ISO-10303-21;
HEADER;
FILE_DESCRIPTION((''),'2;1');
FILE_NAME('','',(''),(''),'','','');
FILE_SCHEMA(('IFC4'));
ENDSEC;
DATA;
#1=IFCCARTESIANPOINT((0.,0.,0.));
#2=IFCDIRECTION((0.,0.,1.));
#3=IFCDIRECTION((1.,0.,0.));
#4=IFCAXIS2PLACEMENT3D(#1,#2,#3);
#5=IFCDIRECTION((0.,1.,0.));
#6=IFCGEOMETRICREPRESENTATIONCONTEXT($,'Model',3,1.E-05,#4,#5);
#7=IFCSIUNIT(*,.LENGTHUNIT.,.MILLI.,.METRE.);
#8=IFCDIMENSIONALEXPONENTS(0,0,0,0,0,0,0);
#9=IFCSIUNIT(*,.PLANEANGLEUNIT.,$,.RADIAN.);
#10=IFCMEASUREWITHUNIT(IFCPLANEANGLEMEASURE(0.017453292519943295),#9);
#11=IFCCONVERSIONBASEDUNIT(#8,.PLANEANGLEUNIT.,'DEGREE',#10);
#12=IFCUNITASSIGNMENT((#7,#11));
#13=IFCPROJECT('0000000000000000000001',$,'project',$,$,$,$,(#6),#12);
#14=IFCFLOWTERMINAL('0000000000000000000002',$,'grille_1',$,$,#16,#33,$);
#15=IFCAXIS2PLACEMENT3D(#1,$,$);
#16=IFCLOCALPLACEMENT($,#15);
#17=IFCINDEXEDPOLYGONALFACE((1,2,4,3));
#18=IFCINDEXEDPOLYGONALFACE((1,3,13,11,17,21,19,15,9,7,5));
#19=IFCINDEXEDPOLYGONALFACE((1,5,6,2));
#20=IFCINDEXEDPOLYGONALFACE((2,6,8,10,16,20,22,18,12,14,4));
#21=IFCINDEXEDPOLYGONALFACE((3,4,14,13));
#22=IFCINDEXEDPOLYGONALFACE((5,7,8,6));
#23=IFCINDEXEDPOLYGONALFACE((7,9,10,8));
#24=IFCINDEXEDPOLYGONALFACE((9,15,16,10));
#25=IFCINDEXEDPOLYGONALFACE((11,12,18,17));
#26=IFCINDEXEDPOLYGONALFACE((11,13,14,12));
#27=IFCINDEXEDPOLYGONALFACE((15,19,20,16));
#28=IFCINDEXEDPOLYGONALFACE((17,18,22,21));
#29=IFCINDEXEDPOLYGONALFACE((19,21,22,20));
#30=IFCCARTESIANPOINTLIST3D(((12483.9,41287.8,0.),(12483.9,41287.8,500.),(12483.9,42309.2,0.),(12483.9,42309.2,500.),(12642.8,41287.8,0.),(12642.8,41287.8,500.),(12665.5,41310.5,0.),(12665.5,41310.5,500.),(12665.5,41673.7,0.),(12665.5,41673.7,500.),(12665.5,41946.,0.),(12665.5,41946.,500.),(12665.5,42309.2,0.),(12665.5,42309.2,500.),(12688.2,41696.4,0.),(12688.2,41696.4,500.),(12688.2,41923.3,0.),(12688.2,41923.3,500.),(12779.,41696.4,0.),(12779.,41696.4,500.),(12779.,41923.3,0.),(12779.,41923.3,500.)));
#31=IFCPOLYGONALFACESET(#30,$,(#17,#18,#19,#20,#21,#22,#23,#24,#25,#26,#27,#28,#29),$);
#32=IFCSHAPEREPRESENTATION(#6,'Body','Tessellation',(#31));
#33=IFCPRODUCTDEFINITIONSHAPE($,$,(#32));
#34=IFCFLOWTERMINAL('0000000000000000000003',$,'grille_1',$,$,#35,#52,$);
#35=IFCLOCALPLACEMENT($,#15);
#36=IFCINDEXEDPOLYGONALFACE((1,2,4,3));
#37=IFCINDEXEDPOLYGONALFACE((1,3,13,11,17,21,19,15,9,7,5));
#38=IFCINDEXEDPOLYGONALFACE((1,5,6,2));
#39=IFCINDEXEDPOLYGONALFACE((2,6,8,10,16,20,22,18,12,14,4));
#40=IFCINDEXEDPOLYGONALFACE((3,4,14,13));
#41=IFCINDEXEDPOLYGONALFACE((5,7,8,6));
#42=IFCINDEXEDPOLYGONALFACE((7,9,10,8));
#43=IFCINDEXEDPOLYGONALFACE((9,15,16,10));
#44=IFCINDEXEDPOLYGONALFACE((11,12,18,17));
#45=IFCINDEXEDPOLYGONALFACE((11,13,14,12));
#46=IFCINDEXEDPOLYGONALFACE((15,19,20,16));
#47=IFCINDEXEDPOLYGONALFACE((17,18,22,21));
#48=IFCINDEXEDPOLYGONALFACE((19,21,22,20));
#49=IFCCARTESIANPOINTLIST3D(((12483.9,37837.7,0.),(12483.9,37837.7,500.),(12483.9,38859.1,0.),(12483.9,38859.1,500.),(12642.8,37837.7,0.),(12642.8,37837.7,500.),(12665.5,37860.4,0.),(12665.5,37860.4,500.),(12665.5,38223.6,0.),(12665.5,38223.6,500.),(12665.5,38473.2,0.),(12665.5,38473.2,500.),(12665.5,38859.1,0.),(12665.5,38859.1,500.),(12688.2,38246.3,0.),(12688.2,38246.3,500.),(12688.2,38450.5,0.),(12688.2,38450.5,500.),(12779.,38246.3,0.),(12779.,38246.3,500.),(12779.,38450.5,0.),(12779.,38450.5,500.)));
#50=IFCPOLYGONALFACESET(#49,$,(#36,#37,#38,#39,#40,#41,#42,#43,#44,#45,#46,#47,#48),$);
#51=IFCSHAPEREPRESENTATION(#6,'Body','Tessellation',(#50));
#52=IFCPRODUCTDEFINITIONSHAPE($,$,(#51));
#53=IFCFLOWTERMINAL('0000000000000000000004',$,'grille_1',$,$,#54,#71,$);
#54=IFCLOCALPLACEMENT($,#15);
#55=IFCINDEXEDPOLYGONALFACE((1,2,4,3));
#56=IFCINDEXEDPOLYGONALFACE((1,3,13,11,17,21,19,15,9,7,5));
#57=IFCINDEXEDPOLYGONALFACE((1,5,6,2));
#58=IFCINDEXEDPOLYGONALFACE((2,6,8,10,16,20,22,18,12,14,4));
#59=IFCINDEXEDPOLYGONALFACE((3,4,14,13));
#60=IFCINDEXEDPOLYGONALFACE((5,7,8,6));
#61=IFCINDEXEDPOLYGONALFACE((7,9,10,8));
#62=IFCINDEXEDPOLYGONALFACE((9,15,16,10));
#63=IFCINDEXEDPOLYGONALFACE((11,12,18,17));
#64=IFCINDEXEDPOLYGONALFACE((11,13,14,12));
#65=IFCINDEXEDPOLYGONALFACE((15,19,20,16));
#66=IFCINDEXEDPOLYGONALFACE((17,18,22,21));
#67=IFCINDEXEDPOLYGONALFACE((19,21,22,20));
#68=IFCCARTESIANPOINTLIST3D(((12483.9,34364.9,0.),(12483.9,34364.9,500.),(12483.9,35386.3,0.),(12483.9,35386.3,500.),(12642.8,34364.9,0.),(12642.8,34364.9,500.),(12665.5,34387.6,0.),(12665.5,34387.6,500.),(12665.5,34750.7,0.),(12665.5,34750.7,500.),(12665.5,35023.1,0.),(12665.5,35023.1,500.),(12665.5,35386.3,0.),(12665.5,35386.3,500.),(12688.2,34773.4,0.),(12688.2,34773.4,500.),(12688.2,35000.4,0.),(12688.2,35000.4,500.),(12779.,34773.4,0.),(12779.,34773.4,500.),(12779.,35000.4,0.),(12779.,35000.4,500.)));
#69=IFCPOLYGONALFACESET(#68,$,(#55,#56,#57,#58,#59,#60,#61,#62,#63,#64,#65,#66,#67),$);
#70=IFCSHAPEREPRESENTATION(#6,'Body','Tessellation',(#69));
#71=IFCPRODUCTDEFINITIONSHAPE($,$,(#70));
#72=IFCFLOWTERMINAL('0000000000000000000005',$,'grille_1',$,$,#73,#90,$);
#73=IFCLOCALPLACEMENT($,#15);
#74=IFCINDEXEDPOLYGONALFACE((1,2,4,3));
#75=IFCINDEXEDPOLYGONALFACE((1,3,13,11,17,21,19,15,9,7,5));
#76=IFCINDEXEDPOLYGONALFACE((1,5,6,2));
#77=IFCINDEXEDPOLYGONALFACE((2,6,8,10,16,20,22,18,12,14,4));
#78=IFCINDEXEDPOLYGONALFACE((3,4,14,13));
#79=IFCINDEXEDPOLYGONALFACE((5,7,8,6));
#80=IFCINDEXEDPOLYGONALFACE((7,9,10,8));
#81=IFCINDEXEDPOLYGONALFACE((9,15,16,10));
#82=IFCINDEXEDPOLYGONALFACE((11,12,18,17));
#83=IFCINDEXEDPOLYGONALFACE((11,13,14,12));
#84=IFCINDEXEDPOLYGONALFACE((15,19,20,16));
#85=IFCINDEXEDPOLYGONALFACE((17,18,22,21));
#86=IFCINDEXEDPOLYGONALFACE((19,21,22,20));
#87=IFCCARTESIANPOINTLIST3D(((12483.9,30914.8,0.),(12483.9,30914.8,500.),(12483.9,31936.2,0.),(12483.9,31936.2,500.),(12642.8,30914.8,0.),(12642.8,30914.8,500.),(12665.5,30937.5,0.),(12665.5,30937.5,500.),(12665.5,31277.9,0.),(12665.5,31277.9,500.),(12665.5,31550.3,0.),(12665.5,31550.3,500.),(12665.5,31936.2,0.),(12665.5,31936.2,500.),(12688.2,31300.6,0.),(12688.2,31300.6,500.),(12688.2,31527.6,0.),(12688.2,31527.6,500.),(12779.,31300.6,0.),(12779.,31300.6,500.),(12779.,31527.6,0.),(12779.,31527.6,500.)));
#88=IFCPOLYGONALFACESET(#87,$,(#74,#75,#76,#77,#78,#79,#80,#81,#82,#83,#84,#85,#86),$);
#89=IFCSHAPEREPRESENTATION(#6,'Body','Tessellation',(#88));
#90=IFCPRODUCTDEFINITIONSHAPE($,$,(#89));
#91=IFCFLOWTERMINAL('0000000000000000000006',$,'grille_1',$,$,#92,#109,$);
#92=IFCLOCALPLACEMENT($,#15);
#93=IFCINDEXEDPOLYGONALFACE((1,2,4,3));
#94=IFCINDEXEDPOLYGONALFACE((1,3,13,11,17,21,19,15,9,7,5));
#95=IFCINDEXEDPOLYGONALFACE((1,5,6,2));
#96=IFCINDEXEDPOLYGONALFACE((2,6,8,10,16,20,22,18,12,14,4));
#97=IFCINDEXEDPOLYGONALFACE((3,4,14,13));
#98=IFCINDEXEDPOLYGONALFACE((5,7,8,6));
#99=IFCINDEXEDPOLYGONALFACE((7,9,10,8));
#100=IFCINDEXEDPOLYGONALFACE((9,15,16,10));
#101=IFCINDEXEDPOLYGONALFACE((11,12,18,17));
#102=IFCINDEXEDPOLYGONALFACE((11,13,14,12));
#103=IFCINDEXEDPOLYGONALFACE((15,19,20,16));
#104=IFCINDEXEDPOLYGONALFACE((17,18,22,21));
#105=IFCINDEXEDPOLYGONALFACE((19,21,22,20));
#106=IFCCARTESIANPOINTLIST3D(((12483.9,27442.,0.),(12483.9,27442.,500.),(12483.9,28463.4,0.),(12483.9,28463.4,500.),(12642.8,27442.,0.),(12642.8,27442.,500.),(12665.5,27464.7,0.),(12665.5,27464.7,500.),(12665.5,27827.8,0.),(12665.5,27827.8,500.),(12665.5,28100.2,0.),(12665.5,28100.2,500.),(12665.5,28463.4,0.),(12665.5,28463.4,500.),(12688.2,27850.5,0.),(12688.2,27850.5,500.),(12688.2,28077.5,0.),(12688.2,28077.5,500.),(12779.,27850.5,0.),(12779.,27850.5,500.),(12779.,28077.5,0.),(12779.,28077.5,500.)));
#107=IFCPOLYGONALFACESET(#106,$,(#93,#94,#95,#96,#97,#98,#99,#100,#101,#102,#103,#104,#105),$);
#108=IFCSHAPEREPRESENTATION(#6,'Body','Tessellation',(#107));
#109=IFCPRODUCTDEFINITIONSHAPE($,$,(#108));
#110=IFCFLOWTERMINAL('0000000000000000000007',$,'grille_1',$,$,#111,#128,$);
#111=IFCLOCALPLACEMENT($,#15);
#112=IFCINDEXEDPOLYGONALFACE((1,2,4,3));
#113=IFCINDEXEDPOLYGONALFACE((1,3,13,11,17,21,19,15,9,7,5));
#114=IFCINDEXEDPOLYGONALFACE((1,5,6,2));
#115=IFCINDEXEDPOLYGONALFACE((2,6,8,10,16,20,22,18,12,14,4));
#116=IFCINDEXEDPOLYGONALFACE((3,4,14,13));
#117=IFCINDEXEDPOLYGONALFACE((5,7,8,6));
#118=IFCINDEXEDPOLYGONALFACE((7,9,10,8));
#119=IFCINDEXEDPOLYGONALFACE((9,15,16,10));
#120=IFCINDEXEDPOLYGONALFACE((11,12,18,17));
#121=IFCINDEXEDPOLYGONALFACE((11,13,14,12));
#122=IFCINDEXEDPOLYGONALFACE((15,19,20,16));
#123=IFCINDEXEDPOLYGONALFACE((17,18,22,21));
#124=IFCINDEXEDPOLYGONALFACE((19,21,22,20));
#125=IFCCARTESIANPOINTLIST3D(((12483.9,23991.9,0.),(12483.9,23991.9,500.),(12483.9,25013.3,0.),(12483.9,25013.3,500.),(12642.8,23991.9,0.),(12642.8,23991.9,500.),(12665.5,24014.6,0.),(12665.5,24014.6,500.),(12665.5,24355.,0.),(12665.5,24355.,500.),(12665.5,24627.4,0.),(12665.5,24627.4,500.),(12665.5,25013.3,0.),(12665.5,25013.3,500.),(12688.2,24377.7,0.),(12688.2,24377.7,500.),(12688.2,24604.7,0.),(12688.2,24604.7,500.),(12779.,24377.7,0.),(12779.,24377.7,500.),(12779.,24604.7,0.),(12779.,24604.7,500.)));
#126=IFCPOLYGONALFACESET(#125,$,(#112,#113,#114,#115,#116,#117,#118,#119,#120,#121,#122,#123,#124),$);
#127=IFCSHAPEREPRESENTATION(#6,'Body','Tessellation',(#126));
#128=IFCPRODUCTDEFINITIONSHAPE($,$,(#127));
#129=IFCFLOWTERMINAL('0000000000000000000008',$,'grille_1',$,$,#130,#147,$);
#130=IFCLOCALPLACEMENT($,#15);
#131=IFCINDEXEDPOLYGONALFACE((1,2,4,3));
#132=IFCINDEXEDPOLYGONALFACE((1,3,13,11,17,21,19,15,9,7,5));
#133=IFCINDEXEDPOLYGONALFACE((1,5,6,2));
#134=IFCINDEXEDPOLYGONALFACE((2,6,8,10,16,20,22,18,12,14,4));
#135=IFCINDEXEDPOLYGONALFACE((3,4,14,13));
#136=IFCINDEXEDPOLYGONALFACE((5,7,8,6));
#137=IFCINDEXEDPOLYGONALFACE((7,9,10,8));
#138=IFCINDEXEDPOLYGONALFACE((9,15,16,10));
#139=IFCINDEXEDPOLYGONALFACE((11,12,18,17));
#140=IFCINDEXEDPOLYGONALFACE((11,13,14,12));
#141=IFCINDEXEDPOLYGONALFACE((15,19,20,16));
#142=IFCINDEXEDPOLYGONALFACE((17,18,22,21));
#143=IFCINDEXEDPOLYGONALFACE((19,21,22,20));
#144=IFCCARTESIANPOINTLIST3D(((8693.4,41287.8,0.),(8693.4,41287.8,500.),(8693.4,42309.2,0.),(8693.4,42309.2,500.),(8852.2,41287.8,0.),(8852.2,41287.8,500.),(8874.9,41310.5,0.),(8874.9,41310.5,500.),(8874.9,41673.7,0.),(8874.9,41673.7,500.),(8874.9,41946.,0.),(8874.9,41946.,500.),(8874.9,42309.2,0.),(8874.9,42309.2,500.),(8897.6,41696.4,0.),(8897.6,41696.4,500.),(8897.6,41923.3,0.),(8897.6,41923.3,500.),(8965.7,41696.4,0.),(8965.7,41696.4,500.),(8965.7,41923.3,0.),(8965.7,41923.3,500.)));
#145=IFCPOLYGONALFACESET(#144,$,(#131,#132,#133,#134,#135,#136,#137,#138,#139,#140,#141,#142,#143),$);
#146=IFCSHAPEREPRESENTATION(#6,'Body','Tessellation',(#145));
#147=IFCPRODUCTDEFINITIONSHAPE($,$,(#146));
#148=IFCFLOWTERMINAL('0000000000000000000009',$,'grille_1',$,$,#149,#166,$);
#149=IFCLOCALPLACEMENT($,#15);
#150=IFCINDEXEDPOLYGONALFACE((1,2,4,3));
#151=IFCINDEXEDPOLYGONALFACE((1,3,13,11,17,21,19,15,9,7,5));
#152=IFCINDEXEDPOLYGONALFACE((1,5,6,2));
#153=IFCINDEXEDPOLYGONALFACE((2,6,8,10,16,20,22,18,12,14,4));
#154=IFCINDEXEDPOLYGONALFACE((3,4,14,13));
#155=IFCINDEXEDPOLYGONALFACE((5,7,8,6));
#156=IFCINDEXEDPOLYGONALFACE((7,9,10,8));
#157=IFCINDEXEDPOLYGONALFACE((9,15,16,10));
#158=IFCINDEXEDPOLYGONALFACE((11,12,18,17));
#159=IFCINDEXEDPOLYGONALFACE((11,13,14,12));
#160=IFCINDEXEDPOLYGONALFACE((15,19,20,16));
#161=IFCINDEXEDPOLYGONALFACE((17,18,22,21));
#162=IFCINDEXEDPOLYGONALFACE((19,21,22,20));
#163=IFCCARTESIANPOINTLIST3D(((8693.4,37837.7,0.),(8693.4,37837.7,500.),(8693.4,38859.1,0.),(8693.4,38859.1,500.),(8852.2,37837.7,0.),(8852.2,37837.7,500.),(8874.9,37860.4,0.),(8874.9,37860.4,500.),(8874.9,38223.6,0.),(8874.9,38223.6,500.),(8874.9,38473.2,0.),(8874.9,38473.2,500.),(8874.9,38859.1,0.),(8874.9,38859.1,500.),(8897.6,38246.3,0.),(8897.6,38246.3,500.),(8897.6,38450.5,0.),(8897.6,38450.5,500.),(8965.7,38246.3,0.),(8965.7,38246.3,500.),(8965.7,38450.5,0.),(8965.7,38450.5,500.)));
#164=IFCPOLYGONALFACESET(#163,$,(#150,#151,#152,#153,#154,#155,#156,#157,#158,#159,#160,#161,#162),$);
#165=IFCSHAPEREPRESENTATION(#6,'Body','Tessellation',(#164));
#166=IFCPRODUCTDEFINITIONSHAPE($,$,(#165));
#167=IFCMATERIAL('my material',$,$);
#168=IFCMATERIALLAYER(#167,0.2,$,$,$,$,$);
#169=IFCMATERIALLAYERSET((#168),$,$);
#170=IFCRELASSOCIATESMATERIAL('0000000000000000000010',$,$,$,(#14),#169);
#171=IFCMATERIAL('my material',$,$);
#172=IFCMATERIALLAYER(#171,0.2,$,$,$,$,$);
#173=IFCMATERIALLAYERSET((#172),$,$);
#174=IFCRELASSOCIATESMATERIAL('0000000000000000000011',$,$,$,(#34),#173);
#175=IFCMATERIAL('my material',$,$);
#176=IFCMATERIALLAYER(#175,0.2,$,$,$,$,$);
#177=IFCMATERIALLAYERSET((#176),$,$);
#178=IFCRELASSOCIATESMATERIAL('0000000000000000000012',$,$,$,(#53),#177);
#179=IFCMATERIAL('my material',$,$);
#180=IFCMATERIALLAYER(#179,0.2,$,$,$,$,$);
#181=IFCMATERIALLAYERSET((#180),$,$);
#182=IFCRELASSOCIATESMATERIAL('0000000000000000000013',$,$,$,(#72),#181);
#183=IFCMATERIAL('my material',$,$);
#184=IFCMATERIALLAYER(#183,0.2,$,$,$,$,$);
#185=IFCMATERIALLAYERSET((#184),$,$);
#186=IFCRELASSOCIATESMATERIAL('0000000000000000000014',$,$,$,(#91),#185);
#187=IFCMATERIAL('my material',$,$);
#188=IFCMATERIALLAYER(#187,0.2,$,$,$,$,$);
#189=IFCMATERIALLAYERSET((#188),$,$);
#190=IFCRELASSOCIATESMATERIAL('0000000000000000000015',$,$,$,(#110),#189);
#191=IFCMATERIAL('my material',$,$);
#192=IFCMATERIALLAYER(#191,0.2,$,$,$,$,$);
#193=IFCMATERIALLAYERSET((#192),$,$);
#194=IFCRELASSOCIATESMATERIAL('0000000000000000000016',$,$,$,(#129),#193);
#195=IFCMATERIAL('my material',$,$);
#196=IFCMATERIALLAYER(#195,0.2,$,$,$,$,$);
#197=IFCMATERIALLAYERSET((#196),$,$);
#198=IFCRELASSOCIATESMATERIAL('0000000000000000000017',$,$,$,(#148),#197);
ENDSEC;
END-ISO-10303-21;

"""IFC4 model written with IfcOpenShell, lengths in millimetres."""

from ifc_helpers import new_model, entity, si_unit, converted_unit, direction, origin_with_axes, place, context, project, polyline, outline, extrude, material, layer, layer_set, layer_usage, element, save


model = new_model("IFC4")

# Units and contexts
model_context = context("Model", 3, precision=1e-05, world=origin_with_axes(), true_north=direction((0.0, 1.0, 0.0)))
ifc_project = project(units=[si_unit("LENGTHUNIT", "METRE", prefix="MILLI"), converted_unit("PLANEANGLEUNIT", "DEGREE", entity("IfcPlaneAngleMeasure", 0.017453292519943295), si_unit("PLANEANGLEUNIT", "RADIAN"), dimensions=[0, 0, 0, 0, 0, 0, 0])], contexts=[model_context])

# Flow terminals
ifc_material_1 = material(Name="my material")
ifc_layer_1 = layer(ifc_material_1, 0.2)
ifc_layer_set_1 = layer_set([ifc_layer_1])
ifc_layer_usage_1 = layer_usage(ifc_layer_set_1, "AXIS2", "POSITIVE", -0.1)
flow_terminal_1_placement = place(None, origin_with_axes())
element("IfcFlowTerminal", 1, at=flow_terminal_1_placement, material=ifc_layer_usage_1, Name="grille_1", context=model_context, shape_type="SweptSolid", body=[
    extrude(outline(polyline([(12483.9, 41287.8), (12642.8, 41287.8), (12665.5, 41310.5), (12665.5, 41673.7), (12688.2, 41696.4), (12779.0, 41696.4), (12779.0, 41923.3), (12688.2, 41923.3), (12665.5, 41946.0), (12665.5, 42309.2), (12483.9, 42309.2), (12483.9, 41287.8)])), origin_with_axes(), (0.0, 0.0, 1.0), 500.0),
])
ifc_material_2 = material(Name="my material")
ifc_layer_2 = layer(ifc_material_2, 0.2)
ifc_layer_set_2 = layer_set([ifc_layer_2])
ifc_layer_usage_2 = layer_usage(ifc_layer_set_2, "AXIS2", "POSITIVE", -0.1)
flow_terminal_2_placement = place(None, origin_with_axes())
element("IfcFlowTerminal", 2, at=flow_terminal_2_placement, material=ifc_layer_usage_2, Name="grille_1", context=model_context, shape_type="SweptSolid", body=[
    extrude(outline(polyline([(12483.9, 37837.7), (12642.8, 37837.7), (12665.5, 37860.4), (12665.5, 38223.6), (12688.2, 38246.3), (12779.0, 38246.3), (12779.0, 38450.5), (12688.2, 38450.5), (12665.5, 38473.2), (12665.5, 38859.1), (12483.9, 38859.1), (12483.9, 37837.7)])), origin_with_axes(), (0.0, 0.0, 1.0), 500.0),
])
ifc_material_3 = material(Name="my material")
ifc_layer_3 = layer(ifc_material_3, 0.2)
ifc_layer_set_3 = layer_set([ifc_layer_3])
ifc_layer_usage_3 = layer_usage(ifc_layer_set_3, "AXIS2", "POSITIVE", -0.1)
flow_terminal_3_placement = place(None, origin_with_axes())
element("IfcFlowTerminal", 3, at=flow_terminal_3_placement, material=ifc_layer_usage_3, Name="grille_1", context=model_context, shape_type="SweptSolid", body=[
    extrude(outline(polyline([(12483.9, 34364.9), (12642.8, 34364.9), (12665.5, 34387.6), (12665.5, 34750.7), (12688.2, 34773.4), (12779.0, 34773.4), (12779.0, 35000.4), (12688.2, 35000.4), (12665.5, 35023.1), (12665.5, 35386.3), (12483.9, 35386.3), (12483.9, 34364.9)])), origin_with_axes(), (0.0, 0.0, 1.0), 500.0),
])
ifc_material_4 = material(Name="my material")
ifc_layer_4 = layer(ifc_material_4, 0.2)
ifc_layer_set_4 = layer_set([ifc_layer_4])
ifc_layer_usage_4 = layer_usage(ifc_layer_set_4, "AXIS2", "POSITIVE", -0.1)
flow_terminal_4_placement = place(None, origin_with_axes())
element("IfcFlowTerminal", 4, at=flow_terminal_4_placement, material=ifc_layer_usage_4, Name="grille_1", context=model_context, shape_type="SweptSolid", body=[
    extrude(outline(polyline([(12483.9, 30914.8), (12642.8, 30914.8), (12665.5, 30937.5), (12665.5, 31277.9), (12688.2, 31300.6), (12779.0, 31300.6), (12779.0, 31527.6), (12688.2, 31527.6), (12665.5, 31550.3), (12665.5, 31936.2), (12483.9, 31936.2), (12483.9, 30914.8)])), origin_with_axes(), (0.0, 0.0, 1.0), 500.0),
])
ifc_material_5 = material(Name="my material")
ifc_layer_5 = layer(ifc_material_5, 0.2)
ifc_layer_set_5 = layer_set([ifc_layer_5])
ifc_layer_usage_5 = layer_usage(ifc_layer_set_5, "AXIS2", "POSITIVE", -0.1)
flow_terminal_5_placement = place(None, origin_with_axes())
element("IfcFlowTerminal", 5, at=flow_terminal_5_placement, material=ifc_layer_usage_5, Name="grille_1", context=model_context, shape_type="SweptSolid", body=[
    extrude(outline(polyline([(12483.9, 27442.0), (12642.8, 27442.0), (12665.5, 27464.7), (12665.5, 27827.8), (12688.2, 27850.5), (12779.0, 27850.5), (12779.0, 28077.5), (12688.2, 28077.5), (12665.5, 28100.2), (12665.5, 28463.4), (12483.9, 28463.4), (12483.9, 27442.0)])), origin_with_axes(), (0.0, 0.0, 1.0), 500.0),
])
ifc_material_6 = material(Name="my material")
ifc_layer_6 = layer(ifc_material_6, 0.2)
ifc_layer_set_6 = layer_set([ifc_layer_6])
ifc_layer_usage_6 = layer_usage(ifc_layer_set_6, "AXIS2", "POSITIVE", -0.1)
flow_terminal_6_placement = place(None, origin_with_axes())
element("IfcFlowTerminal", 6, at=flow_terminal_6_placement, material=ifc_layer_usage_6, Name="grille_1", context=model_context, shape_type="SweptSolid", body=[
    extrude(outline(polyline([(12483.9, 23991.9), (12642.8, 23991.9), (12665.5, 24014.6), (12665.5, 24355.0), (12688.2, 24377.7), (12779.0, 24377.7), (12779.0, 24604.7), (12688.2, 24604.7), (12665.5, 24627.4), (12665.5, 25013.3), (12483.9, 25013.3), (12483.9, 23991.9)])), origin_with_axes(), (0.0, 0.0, 1.0), 500.0),
])
ifc_material_7 = material(Name="my material")
ifc_layer_7 = layer(ifc_material_7, 0.2)
ifc_layer_set_7 = layer_set([ifc_layer_7])
ifc_layer_usage_7 = layer_usage(ifc_layer_set_7, "AXIS2", "POSITIVE", -0.1)
flow_terminal_7_placement = place(None, origin_with_axes())
element("IfcFlowTerminal", 7, at=flow_terminal_7_placement, material=ifc_layer_usage_7, Name="grille_1", context=model_context, shape_type="SweptSolid", body=[
    extrude(outline(polyline([(8693.4, 41287.8), (8852.2, 41287.8), (8874.9, 41310.5), (8874.9, 41673.7), (8897.6, 41696.4), (8965.7, 41696.4), (8965.7, 41923.3), (8897.6, 41923.3), (8874.9, 41946.0), (8874.9, 42309.2), (8693.4, 42309.2), (8693.4, 41287.8)])), origin_with_axes(), (0.0, 0.0, 1.0), 500.0),
])
ifc_material_8 = material(Name="my material")
ifc_layer_8 = layer(ifc_material_8, 0.2)
ifc_layer_set_8 = layer_set([ifc_layer_8])
ifc_layer_usage_8 = layer_usage(ifc_layer_set_8, "AXIS2", "POSITIVE", -0.1)
flow_terminal_8_placement = place(None, origin_with_axes())
element("IfcFlowTerminal", 8, at=flow_terminal_8_placement, material=ifc_layer_usage_8, Name="grille_1", context=model_context, shape_type="SweptSolid", body=[
    extrude(outline(polyline([(8693.4, 37837.7), (8852.2, 37837.7), (8874.9, 37860.4), (8874.9, 38223.6), (8897.6, 38246.3), (8965.7, 38246.3), (8965.7, 38450.5), (8897.6, 38450.5), (8874.9, 38473.2), (8874.9, 38859.1), (8693.4, 38859.1), (8693.4, 37837.7)])), origin_with_axes(), (0.0, 0.0, 1.0), 500.0),
])

save(model, "model.ifc")
